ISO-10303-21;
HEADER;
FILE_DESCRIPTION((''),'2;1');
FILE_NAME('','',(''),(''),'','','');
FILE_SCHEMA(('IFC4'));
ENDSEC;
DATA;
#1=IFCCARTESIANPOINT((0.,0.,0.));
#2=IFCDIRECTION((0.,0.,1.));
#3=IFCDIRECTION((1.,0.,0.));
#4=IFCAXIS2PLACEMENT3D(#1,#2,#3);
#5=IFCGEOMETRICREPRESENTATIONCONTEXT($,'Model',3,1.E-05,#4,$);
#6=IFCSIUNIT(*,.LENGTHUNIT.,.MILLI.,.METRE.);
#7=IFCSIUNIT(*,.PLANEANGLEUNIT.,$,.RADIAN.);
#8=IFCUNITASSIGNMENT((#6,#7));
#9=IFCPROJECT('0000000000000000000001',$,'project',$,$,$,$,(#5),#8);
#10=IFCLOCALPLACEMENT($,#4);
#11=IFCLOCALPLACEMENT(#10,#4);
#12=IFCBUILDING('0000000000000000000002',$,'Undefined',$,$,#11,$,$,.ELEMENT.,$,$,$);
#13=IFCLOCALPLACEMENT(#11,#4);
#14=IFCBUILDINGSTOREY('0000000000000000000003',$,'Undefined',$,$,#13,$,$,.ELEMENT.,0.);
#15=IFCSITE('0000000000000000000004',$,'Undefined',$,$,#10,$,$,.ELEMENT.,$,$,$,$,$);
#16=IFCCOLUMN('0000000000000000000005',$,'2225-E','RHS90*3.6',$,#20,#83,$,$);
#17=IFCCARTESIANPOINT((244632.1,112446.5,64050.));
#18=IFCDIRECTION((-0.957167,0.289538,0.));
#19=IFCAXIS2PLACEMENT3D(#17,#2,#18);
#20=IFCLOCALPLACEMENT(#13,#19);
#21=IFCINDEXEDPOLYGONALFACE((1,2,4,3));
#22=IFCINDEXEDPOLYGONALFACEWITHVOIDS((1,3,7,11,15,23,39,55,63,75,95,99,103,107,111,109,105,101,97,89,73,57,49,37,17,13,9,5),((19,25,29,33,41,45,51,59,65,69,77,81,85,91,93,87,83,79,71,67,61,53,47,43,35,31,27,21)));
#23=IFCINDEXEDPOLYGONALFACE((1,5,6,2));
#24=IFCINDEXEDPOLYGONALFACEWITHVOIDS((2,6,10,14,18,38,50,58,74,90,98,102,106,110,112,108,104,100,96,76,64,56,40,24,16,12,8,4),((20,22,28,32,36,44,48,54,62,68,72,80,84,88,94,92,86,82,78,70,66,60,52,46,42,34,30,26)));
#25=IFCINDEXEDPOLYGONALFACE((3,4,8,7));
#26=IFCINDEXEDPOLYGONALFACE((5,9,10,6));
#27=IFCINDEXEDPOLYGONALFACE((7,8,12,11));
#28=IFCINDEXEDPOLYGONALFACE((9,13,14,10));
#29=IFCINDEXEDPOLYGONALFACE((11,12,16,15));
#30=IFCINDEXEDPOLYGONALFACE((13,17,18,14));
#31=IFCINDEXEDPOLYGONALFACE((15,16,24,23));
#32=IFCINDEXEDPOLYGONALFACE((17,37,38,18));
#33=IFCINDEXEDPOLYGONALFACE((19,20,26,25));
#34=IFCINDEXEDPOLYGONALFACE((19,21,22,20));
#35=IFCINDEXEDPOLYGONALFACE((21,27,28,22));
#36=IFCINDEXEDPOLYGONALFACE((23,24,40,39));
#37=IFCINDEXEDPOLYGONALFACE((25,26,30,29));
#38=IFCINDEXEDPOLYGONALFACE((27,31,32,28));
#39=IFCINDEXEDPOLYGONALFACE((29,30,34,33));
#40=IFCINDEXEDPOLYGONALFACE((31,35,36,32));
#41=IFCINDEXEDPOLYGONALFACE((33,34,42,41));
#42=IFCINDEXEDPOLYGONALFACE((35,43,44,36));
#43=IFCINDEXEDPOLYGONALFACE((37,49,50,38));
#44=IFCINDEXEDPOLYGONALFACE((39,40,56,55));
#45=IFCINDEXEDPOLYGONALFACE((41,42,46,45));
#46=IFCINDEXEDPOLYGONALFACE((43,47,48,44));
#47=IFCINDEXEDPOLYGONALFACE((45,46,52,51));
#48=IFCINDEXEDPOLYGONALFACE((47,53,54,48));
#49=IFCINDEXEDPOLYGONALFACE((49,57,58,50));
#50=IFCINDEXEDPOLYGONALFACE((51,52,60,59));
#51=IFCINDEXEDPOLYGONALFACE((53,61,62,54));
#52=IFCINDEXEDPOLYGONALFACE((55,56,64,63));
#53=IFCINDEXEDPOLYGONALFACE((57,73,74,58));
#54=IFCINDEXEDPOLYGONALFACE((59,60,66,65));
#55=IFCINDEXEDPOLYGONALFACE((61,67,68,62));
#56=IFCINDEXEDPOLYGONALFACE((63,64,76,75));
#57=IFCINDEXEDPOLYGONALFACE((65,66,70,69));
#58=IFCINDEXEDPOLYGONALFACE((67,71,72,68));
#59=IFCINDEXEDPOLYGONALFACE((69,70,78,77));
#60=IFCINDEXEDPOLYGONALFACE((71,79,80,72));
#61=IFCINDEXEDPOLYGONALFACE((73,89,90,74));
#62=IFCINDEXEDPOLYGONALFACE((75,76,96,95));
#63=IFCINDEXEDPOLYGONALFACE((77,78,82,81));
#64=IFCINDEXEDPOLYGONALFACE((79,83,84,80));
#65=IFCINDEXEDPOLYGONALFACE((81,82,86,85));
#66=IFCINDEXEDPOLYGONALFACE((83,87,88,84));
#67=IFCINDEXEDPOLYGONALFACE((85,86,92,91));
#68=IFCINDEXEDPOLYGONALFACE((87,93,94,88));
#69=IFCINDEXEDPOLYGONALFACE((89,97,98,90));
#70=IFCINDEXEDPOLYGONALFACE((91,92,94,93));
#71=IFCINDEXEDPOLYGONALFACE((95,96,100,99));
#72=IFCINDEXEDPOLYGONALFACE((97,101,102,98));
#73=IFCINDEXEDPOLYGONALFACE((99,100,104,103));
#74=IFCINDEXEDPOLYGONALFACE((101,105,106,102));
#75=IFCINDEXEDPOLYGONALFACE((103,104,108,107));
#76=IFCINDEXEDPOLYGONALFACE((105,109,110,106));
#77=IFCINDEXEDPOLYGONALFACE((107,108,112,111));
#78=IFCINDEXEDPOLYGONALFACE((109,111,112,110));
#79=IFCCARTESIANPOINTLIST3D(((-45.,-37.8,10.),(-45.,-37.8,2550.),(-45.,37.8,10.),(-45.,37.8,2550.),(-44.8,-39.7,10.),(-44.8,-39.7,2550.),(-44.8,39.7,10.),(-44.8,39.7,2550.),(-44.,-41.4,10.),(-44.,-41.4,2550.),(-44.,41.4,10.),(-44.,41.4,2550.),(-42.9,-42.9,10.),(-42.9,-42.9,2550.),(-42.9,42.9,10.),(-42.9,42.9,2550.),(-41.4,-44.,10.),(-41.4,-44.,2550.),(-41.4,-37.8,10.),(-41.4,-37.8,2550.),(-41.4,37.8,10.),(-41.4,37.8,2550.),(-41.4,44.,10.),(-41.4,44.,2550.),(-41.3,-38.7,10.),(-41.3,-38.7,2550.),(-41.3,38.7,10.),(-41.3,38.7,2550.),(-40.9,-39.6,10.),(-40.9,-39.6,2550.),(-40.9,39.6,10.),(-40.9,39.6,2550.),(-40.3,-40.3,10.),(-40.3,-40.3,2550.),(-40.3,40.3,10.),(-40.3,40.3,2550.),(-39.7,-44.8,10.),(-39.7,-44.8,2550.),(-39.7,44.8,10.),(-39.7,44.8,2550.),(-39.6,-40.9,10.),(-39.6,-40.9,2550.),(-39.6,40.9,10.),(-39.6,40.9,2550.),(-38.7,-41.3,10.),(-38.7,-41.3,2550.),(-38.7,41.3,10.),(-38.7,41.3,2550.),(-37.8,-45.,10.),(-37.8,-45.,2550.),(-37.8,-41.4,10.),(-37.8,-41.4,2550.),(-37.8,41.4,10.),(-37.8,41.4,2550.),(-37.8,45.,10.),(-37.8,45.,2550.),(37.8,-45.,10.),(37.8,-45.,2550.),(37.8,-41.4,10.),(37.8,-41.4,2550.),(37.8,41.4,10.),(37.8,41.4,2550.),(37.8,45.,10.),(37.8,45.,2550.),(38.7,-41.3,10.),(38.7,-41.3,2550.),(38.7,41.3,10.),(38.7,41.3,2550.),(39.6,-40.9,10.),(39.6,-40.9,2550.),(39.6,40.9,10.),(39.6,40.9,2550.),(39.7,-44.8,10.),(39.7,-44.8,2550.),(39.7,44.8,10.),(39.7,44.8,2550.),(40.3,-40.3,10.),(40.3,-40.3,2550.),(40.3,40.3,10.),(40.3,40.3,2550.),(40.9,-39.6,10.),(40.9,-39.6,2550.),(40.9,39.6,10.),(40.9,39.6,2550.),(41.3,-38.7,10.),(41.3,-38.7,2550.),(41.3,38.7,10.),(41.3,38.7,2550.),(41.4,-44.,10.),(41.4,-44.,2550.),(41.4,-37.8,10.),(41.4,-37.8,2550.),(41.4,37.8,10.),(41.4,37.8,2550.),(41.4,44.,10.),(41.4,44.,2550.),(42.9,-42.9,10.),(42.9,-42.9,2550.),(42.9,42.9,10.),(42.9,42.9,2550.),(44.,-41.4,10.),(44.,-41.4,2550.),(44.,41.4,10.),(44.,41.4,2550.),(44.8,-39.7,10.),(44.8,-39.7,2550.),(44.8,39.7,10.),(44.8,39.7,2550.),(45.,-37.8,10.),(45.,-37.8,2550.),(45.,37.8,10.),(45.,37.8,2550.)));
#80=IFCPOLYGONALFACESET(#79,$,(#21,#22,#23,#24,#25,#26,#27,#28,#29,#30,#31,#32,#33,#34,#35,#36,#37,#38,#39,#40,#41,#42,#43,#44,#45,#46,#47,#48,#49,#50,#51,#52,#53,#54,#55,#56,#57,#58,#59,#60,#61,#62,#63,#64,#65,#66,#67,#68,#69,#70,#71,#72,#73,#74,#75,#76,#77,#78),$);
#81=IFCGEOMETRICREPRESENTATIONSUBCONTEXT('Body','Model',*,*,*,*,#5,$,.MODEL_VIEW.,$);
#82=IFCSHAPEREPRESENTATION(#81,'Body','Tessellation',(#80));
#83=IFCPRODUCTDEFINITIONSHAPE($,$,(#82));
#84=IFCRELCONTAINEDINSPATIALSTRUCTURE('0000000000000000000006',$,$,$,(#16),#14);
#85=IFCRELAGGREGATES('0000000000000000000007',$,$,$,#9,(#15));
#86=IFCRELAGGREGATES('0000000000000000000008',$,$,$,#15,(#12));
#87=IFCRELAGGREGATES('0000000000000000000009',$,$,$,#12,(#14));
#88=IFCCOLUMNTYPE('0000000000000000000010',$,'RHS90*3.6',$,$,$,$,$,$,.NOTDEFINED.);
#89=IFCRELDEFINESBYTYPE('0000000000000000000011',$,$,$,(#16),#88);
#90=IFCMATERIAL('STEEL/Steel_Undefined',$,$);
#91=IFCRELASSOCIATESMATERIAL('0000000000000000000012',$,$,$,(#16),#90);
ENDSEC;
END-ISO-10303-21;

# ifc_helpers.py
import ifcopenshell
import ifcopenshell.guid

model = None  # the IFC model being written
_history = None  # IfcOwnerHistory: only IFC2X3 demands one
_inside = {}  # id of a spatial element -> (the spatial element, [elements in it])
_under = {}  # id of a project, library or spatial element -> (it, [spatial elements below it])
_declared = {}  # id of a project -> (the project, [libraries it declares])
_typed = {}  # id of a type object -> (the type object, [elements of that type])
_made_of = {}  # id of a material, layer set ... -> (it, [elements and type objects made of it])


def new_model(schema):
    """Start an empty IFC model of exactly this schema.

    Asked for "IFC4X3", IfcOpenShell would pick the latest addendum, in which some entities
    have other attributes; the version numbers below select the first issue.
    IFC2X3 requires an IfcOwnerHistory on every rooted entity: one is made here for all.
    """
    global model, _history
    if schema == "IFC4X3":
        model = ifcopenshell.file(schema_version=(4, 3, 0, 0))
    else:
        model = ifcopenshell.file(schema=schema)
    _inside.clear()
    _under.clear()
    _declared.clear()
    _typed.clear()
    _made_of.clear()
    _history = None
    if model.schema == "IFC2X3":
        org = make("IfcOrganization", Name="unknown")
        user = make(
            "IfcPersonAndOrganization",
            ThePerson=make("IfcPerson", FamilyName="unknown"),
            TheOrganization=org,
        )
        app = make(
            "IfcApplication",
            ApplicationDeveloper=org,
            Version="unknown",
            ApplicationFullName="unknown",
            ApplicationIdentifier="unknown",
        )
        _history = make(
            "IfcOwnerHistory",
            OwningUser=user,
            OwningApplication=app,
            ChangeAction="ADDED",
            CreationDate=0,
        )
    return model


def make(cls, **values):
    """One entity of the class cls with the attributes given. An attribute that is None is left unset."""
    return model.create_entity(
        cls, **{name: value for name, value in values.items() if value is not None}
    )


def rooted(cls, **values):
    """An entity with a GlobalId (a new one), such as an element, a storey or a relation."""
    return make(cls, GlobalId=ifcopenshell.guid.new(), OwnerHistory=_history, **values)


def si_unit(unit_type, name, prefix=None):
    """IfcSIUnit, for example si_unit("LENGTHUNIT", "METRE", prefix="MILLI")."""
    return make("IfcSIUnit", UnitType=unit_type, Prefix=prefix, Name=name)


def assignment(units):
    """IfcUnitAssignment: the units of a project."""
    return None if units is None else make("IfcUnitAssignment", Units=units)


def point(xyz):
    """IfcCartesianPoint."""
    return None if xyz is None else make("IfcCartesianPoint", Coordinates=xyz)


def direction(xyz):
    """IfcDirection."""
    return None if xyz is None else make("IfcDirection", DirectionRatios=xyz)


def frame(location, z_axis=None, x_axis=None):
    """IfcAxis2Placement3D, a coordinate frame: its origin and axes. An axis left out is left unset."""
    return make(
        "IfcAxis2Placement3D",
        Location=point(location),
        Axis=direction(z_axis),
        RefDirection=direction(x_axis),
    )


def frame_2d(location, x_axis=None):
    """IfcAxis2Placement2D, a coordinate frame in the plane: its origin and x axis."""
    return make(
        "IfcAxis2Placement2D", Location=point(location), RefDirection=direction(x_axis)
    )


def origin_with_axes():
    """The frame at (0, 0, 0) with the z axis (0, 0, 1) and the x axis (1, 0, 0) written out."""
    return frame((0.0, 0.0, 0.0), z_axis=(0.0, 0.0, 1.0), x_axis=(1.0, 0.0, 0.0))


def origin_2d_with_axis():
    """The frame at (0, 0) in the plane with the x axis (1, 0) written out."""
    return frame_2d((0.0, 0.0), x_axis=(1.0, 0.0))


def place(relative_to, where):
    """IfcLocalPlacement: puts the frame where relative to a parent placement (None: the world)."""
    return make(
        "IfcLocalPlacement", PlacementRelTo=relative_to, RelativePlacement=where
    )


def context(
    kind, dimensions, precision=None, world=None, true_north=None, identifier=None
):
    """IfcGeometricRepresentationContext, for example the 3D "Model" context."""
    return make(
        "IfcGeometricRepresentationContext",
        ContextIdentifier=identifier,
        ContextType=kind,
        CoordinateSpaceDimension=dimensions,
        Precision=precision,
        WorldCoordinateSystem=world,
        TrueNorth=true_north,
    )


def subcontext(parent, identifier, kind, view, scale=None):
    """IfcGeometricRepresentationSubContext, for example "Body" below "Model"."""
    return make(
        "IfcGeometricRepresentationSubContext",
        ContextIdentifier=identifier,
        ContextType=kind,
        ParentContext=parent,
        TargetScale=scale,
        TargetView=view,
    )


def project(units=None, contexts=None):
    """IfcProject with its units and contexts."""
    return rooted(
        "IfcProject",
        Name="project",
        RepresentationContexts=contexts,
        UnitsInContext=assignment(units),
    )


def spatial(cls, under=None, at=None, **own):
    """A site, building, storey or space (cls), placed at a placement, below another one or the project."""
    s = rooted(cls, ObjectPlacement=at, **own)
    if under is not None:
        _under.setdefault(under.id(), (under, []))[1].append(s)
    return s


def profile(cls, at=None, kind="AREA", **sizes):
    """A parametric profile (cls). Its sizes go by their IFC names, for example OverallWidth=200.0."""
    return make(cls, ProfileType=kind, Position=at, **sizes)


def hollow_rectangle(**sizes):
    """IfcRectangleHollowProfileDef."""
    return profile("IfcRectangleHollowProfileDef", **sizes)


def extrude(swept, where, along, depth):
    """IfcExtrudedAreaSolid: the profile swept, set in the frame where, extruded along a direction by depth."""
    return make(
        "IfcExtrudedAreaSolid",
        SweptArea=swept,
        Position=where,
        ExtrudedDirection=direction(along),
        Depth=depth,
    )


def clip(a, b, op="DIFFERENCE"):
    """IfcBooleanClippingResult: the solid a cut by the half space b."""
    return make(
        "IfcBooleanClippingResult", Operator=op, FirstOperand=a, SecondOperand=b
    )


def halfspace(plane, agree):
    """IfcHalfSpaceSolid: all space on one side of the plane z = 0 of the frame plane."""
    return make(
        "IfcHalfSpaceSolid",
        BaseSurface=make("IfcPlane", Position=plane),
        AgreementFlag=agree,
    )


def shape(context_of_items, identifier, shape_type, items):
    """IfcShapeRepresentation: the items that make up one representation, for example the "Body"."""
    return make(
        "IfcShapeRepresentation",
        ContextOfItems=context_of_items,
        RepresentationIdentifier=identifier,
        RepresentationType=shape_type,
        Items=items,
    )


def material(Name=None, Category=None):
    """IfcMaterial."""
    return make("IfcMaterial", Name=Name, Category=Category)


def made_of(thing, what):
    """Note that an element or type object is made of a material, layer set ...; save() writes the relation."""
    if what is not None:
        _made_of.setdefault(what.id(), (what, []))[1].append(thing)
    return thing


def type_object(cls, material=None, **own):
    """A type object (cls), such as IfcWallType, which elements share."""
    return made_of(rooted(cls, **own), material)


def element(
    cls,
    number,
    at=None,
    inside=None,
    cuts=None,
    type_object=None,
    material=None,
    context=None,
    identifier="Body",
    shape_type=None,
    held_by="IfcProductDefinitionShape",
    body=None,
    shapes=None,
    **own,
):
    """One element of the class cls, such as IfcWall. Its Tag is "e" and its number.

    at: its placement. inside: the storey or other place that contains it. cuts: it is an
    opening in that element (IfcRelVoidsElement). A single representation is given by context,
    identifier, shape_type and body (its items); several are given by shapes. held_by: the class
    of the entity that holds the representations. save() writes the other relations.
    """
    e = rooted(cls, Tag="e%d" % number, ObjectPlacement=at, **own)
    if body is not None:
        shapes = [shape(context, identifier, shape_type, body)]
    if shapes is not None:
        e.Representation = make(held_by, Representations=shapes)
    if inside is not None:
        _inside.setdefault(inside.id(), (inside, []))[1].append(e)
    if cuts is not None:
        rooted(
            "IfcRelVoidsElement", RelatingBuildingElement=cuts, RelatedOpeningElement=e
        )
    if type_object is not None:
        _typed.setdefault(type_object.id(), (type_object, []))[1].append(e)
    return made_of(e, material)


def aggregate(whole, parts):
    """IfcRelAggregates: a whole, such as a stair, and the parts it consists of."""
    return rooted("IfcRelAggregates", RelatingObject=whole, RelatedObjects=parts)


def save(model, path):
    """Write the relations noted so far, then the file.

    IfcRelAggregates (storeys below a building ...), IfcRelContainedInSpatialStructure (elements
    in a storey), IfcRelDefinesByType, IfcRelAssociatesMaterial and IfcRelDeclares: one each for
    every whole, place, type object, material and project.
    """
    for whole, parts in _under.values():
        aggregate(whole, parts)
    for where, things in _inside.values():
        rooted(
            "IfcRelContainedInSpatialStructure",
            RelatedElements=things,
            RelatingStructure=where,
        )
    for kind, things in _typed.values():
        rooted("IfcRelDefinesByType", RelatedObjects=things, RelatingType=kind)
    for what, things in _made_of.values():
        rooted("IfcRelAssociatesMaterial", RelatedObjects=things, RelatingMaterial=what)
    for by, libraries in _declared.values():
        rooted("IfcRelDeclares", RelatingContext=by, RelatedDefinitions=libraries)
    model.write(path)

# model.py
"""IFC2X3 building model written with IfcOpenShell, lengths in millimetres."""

from ifc_helpers import new_model, si_unit, frame, origin_with_axes, origin_2d_with_axis, place, context, subcontext, project, spatial, hollow_rectangle, extrude, clip, halfspace, material, type_object, element, save


model = new_model("IFC2X3")

# Units and contexts
model_context = context("Model", 3, precision=1e-05, world=origin_with_axes())
body_context = subcontext(model_context, "Body", "Model", "MODEL_VIEW")
ifc_project = project(units=[si_unit("LENGTHUNIT", "METRE", prefix="MILLI"), si_unit("PLANEANGLEUNIT", "RADIAN")], contexts=[model_context])

# Site, building, storey
site_placement = place(None, origin_with_axes())
site = spatial("IfcSite", under=ifc_project, at=site_placement, Name="Undefined", CompositionType="ELEMENT")
building_placement = place(site_placement, origin_with_axes())
building = spatial("IfcBuilding", under=site, at=building_placement, Name="Undefined", CompositionType="ELEMENT")
storey_placement = place(building_placement, origin_with_axes())
storey = spatial("IfcBuildingStorey", under=building, at=storey_placement, Name="Undefined", CompositionType="ELEMENT", Elevation=0.0)

# Column
ifc_material_1 = material(Name="STEEL/Steel_Undefined")
column_type = type_object("IfcColumnType", Name="RHS90*3.6", PredefinedType="NOTDEFINED")
column_placement = place(storey_placement, frame((244632.1, 112446.5, 64050.0), z_axis=(0.0, 0.0, 1.0), x_axis=(-0.957167, 0.289538, 0.0)))
element("IfcColumn", 1, at=column_placement, inside=storey, type_object=column_type, material=ifc_material_1, Name="2225-E", Description="RHS90*3.6", context=body_context, shape_type="Clipping", body=[
    clip(extrude(hollow_rectangle(XDim=90.0, YDim=90.0, WallThickness=3.6, InnerFilletRadius=3.6, OuterFilletRadius=7.2, at=origin_2d_with_axis()), frame((0.0, 0.0, 2550.0), z_axis=(0.0, 0.0, -1.0), x_axis=(0.0, 1.0, 0.0)), (0.0, 0.0, 1.0), 2550.0), halfspace(frame((-45.0, 0.0, 10.0), z_axis=(0.0, 0.0, 1.0), x_axis=(0.0, 1.0, 0.0)), True)),
])

save(model, "model.ifc")
